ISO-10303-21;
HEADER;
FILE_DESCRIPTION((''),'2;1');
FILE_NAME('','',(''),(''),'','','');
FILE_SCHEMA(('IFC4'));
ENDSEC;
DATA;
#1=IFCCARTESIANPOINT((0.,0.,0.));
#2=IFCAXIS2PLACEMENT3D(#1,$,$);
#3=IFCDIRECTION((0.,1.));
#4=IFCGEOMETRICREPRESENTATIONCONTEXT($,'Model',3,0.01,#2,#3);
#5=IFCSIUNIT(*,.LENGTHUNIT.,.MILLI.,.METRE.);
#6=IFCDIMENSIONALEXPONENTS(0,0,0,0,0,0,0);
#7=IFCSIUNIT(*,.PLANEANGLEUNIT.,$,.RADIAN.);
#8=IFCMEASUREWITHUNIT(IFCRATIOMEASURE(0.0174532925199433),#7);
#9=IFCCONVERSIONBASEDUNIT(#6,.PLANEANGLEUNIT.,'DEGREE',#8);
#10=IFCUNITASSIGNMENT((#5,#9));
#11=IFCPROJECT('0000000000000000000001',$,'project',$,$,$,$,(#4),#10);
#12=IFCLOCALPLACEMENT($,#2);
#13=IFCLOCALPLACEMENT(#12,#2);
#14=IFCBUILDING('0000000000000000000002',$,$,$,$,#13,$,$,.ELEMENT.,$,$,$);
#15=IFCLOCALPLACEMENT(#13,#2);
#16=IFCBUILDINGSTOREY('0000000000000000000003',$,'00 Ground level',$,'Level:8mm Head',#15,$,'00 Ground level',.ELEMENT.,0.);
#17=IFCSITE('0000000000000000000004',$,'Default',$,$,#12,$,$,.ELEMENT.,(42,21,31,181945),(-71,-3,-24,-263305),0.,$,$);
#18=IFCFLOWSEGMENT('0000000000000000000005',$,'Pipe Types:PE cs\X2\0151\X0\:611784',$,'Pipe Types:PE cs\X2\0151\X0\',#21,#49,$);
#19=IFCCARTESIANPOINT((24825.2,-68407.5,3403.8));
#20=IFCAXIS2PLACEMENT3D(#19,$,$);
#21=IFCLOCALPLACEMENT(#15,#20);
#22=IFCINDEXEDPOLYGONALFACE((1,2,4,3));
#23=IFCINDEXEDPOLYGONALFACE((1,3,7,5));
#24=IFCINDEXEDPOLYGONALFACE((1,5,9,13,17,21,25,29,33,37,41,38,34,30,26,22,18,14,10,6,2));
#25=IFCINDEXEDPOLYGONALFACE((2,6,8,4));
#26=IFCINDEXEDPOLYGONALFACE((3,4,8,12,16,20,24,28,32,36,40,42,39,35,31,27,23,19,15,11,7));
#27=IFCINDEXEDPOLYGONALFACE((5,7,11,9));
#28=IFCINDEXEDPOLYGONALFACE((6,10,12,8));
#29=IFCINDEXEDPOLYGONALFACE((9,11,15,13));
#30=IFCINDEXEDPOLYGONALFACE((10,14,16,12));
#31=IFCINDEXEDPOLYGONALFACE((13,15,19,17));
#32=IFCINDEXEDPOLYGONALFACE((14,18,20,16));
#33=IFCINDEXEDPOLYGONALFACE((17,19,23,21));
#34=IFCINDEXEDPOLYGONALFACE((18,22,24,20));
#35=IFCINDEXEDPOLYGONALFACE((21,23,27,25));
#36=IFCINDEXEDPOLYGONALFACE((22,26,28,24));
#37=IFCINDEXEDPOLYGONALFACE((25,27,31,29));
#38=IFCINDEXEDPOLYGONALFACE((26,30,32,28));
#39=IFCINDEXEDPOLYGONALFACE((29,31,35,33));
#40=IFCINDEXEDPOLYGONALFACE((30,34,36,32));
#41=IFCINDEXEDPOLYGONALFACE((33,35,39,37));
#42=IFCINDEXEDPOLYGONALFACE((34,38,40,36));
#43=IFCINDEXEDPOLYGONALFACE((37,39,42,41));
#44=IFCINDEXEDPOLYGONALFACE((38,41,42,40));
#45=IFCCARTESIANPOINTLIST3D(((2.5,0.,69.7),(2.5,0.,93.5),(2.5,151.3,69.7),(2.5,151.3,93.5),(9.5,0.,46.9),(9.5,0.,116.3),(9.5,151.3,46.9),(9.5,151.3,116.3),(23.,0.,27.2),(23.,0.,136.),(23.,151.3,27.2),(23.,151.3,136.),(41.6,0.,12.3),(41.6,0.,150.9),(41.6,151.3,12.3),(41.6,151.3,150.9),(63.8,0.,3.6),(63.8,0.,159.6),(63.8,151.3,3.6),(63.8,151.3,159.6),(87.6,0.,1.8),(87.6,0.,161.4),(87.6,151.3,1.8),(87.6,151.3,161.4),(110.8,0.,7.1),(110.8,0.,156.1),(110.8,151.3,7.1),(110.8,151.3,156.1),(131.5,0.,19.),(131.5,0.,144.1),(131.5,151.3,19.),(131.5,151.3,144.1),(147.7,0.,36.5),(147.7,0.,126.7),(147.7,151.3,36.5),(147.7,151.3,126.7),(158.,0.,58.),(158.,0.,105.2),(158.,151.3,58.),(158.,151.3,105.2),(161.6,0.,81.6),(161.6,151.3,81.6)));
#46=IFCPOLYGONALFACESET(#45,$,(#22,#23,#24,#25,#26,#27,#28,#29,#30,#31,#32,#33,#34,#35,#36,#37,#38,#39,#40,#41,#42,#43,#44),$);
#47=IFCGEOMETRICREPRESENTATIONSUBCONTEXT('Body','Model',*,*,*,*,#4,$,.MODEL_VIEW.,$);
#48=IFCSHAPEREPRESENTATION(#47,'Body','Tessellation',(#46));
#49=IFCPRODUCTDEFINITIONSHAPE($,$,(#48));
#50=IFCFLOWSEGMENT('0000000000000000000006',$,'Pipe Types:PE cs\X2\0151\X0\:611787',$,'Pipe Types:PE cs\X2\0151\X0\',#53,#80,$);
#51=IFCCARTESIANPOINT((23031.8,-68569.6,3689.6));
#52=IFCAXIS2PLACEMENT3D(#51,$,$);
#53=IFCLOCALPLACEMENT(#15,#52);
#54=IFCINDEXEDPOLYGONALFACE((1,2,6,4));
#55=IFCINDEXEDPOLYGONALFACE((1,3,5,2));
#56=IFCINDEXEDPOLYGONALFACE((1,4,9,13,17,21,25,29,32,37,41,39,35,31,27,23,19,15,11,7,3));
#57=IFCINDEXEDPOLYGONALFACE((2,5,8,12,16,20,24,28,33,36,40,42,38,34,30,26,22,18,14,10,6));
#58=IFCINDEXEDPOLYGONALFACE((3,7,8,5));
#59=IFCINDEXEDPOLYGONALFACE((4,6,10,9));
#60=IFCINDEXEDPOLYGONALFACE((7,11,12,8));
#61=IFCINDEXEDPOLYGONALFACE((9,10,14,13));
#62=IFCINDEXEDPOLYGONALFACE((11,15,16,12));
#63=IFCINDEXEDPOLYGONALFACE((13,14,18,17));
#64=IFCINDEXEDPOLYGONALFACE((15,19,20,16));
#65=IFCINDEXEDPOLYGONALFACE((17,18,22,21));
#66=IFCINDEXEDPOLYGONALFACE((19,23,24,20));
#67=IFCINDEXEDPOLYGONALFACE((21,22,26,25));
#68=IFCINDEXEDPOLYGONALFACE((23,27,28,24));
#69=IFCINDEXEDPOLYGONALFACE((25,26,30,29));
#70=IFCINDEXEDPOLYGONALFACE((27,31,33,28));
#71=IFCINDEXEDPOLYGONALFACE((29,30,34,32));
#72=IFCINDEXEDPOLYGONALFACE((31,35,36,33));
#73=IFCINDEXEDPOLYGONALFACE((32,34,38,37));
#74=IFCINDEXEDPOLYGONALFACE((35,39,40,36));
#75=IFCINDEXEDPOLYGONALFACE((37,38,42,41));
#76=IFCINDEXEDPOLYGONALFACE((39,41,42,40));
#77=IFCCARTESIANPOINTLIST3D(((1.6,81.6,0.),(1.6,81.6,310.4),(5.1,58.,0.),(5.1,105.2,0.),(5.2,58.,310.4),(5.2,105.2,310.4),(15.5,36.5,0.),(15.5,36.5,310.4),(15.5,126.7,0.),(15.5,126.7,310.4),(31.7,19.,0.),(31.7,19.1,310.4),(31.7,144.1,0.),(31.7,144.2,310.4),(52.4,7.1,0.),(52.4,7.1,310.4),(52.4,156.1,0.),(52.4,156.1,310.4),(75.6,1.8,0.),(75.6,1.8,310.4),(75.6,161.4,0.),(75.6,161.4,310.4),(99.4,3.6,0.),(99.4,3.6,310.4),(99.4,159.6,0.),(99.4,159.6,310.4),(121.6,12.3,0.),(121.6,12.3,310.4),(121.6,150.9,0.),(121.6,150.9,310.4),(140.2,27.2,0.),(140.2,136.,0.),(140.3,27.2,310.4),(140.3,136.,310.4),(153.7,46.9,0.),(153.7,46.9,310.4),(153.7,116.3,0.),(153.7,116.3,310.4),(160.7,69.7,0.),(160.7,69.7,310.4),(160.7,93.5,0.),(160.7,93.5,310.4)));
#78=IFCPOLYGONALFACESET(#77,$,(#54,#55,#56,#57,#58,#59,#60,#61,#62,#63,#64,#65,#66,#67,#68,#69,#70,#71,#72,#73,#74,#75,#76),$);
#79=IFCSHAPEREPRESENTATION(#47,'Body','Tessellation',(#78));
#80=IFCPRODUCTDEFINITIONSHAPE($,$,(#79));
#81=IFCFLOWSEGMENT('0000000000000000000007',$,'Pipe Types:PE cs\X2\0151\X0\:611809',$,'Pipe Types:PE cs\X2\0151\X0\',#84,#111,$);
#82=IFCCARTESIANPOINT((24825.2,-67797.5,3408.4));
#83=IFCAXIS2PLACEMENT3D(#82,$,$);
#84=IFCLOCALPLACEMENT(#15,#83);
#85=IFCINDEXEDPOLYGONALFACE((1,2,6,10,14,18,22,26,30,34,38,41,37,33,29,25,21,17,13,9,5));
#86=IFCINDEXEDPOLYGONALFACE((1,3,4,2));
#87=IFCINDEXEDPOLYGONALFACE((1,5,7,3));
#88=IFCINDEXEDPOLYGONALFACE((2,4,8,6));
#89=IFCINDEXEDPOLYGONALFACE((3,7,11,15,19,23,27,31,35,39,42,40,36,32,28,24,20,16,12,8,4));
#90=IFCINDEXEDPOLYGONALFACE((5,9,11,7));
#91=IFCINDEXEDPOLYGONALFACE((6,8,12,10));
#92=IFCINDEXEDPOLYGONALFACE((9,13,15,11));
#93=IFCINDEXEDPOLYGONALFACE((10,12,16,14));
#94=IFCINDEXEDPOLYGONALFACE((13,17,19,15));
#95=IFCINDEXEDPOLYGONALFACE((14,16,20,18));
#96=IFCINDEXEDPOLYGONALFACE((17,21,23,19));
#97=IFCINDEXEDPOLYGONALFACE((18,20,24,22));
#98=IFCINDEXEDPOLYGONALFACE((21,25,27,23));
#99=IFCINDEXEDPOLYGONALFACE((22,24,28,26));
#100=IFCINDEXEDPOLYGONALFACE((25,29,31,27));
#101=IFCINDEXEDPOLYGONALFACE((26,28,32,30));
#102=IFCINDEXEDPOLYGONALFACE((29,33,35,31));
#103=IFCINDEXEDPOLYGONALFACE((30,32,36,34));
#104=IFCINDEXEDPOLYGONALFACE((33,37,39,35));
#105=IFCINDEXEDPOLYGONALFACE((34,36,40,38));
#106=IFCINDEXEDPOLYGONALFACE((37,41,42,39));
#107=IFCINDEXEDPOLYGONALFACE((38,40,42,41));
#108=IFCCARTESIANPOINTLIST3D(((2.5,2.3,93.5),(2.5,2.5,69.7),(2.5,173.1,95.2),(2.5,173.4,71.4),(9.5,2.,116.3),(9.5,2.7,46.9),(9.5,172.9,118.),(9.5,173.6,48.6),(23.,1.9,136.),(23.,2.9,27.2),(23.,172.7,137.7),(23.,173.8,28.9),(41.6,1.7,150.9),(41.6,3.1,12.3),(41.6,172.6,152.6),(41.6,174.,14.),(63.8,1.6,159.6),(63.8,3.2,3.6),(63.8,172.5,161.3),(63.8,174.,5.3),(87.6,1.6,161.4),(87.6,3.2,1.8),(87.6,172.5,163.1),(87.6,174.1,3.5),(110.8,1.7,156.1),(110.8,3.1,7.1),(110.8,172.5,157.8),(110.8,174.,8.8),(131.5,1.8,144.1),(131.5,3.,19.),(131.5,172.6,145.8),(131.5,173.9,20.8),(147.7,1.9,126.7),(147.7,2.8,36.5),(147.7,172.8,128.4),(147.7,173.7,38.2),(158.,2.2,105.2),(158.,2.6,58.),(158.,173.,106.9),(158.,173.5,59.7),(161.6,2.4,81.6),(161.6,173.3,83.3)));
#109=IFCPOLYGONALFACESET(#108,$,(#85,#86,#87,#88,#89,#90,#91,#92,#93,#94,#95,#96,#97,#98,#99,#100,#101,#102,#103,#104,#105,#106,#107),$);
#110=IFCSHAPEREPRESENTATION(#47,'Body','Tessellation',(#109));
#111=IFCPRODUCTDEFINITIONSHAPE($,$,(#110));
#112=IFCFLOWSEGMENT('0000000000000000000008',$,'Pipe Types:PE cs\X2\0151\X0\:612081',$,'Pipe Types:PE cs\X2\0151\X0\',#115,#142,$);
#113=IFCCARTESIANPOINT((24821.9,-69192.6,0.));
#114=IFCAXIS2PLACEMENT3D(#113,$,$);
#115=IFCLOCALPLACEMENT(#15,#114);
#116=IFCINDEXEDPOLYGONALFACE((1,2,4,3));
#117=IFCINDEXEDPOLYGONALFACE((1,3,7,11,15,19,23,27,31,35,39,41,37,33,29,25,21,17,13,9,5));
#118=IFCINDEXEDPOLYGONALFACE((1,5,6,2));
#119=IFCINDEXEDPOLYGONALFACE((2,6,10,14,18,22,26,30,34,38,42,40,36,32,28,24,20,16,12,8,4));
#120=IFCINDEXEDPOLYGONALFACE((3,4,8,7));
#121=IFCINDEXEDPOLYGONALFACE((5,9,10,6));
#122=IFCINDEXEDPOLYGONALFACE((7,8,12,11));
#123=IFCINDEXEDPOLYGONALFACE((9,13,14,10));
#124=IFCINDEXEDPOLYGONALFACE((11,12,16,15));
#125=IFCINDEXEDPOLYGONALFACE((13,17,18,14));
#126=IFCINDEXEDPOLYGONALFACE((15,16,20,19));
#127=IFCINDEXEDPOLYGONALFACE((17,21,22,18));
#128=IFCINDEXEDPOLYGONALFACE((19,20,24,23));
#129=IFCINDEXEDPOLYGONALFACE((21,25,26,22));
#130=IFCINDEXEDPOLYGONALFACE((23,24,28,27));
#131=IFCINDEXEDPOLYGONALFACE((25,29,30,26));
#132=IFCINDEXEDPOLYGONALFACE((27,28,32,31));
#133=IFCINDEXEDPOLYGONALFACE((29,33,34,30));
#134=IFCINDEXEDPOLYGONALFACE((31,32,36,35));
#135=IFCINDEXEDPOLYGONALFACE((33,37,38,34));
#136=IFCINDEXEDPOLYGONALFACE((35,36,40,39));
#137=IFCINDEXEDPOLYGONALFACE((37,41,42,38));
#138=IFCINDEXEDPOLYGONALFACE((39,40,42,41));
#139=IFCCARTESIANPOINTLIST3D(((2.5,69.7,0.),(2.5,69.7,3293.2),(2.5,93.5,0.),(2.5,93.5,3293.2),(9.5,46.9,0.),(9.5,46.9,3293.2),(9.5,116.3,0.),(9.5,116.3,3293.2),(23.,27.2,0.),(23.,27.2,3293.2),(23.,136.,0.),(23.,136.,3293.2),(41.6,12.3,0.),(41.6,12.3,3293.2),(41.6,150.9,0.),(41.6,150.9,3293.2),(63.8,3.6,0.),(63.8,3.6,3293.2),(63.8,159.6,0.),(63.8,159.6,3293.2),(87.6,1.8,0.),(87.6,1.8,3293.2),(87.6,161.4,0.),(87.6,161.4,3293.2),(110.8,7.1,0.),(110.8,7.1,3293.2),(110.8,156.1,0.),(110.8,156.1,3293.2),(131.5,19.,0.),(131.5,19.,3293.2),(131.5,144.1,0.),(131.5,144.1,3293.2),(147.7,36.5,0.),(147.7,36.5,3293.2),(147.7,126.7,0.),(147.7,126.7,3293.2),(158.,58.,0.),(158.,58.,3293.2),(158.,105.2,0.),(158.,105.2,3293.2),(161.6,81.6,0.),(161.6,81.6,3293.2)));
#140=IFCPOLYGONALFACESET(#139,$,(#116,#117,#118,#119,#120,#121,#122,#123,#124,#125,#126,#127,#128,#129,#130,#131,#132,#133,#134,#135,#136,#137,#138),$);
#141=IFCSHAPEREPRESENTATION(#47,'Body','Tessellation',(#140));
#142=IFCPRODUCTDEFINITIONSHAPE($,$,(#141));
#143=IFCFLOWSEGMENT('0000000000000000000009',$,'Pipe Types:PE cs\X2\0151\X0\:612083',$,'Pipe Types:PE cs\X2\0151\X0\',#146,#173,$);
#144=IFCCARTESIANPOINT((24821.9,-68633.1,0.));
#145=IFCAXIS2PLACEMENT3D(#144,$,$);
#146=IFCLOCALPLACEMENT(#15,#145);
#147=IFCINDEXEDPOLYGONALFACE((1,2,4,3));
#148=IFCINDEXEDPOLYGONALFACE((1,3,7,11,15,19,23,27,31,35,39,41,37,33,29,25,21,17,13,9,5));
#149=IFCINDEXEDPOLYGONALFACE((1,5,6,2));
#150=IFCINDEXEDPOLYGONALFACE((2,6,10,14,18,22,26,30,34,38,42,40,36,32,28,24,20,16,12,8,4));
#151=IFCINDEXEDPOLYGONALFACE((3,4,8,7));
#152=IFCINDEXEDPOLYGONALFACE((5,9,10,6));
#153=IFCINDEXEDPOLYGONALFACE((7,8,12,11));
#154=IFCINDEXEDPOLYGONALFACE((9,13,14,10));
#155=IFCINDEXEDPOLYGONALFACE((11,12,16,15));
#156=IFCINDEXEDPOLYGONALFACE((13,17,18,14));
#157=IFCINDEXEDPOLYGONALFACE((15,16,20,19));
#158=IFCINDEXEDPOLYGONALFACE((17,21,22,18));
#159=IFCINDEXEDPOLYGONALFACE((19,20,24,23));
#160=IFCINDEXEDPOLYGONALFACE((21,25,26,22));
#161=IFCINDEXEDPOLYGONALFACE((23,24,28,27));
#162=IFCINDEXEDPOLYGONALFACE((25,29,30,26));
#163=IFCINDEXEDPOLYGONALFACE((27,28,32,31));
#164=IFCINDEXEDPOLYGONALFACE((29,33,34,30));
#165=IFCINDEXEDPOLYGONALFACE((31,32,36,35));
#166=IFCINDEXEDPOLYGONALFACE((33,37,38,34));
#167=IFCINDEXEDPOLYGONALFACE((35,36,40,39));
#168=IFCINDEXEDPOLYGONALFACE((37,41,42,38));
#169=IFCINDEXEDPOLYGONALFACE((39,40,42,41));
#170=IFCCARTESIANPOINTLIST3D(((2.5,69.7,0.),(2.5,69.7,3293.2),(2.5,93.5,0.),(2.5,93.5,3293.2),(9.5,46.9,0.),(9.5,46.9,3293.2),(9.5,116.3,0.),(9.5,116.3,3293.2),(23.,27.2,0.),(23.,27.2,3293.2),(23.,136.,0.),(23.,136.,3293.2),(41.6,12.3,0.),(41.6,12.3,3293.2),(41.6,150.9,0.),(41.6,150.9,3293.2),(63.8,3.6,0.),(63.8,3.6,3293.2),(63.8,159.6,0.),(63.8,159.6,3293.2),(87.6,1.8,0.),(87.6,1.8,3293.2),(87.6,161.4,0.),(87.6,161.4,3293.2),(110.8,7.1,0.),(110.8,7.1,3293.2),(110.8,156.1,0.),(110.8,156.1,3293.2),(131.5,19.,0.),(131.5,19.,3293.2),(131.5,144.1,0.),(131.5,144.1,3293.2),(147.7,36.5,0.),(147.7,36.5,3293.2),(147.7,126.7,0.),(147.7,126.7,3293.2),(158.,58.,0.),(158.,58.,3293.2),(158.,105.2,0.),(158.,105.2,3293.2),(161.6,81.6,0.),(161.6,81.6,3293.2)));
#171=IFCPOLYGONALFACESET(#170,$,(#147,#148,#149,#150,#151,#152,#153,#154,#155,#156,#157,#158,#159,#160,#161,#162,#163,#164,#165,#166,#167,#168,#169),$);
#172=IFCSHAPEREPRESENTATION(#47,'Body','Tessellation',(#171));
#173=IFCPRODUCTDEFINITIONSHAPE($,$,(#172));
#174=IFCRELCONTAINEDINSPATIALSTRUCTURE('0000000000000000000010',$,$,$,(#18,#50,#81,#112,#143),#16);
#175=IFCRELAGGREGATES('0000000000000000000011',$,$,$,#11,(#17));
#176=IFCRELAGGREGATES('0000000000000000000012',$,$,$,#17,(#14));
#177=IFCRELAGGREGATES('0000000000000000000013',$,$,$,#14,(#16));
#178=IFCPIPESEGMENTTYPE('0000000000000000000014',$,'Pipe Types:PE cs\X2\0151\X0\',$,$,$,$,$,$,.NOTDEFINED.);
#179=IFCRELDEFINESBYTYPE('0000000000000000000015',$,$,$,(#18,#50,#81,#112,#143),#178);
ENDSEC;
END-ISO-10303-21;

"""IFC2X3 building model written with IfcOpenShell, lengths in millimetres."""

from ifc_helpers import new_model, entity, si_unit, converted_unit, direction, frame, frame_2d, origin, origin_2d_with_axis, place, context, subcontext, project, spatial, circle, extrude, type_object, element, save


model = new_model("IFC2X3")

# Units and contexts
model_context = context("Model", 3, precision=0.01, world=origin(), true_north=direction((0.0, 1.0)))
body_context = subcontext(model_context, "Body", "Model", "MODEL_VIEW")
ifc_project = project(units=[si_unit("LENGTHUNIT", "METRE", prefix="MILLI"), converted_unit("PLANEANGLEUNIT", "DEGREE", entity("IfcRatioMeasure", 0.0174532925199433), si_unit("PLANEANGLEUNIT", "RADIAN"), dimensions=[0, 0, 0, 0, 0, 0, 0])], contexts=[model_context])

# Site, building, storey
site_placement = place(None, origin())
site = spatial("IfcSite", under=ifc_project, at=site_placement, Name="Default", CompositionType="ELEMENT", RefLatitude=(42, 21, 31, 181945), RefLongitude=(-71, -3, -24, -263305), RefElevation=0.0)
building_placement = place(site_placement, origin())
building = spatial("IfcBuilding", under=site, at=building_placement, CompositionType="ELEMENT")
storey_placement = place(building_placement, origin())
storey = spatial("IfcBuildingStorey", under=building, at=storey_placement, Name="00 Ground level", ObjectType="Level:8mm Head", LongName="00 Ground level", CompositionType="ELEMENT", Elevation=0.0)

# Flow segments
pipe_segment_type = type_object("IfcPipeSegmentType", Name="Pipe Types:PE cső", PredefinedType="NOTDEFINED")
flow_segment_1_placement = place(storey_placement, frame((24825.2, -68407.5, 3403.8)))
element("IfcFlowSegment", 1, at=flow_segment_1_placement, inside=storey, type_object=pipe_segment_type, Name="Pipe Types:PE cső:611784", ObjectType="Pipe Types:PE cső", context=body_context, shape_type="SweptSolid", body=[
    extrude(circle(Radius=80.0, at=origin_2d_with_axis()), frame((81.6, 0.0, 81.6), z_axis=(0.0, 1.0, 0.0), x_axis=(1.0, 0.0, 0.0)), (0.0, 0.0, 1.0), 151.3),
])
flow_segment_2_placement = place(storey_placement, frame((23031.8, -68569.6, 3689.6)))
element("IfcFlowSegment", 2, at=flow_segment_2_placement, inside=storey, type_object=pipe_segment_type, Name="Pipe Types:PE cső:611787", ObjectType="Pipe Types:PE cső", context=body_context, shape_type="SweptSolid", body=[
    extrude(circle(Radius=80.0, at=frame_2d((0.0, 0.0), x_axis=(1.0, 0.0))), frame((81.6, 81.6, 0.0), z_axis=(0.000084, 0.000051, 1.0), x_axis=(-1.0, 0.0, 0.000084)), (0.0, 0.0, 1.0), 310.4),
])
flow_segment_3_placement = place(storey_placement, frame((24825.2, -67797.5, 3408.4)))
element("IfcFlowSegment", 3, at=flow_segment_3_placement, inside=storey, type_object=pipe_segment_type, Name="Pipe Types:PE cső:611809", ObjectType="Pipe Types:PE cső", context=body_context, shape_type="SweptSolid", body=[
    extrude(circle(Radius=80.0, at=origin_2d_with_axis()), frame((81.6, 2.4, 81.6), z_axis=(0.0, 0.99995, 0.01), x_axis=(1.0, 0.0, 0.0)), (0.0, 0.0, 1.0), 170.9),
])
for number, where, name in (
    (4, (24821.9, -69192.6, 0.0), "Pipe Types:PE cső:612081"),
    (5, (24821.9, -68633.1, 0.0), "Pipe Types:PE cső:612083"),
):
    element("IfcFlowSegment", number, at=place(storey_placement, frame(where)), inside=storey, type_object=pipe_segment_type, Name=name, ObjectType="Pipe Types:PE cső", context=body_context, shape_type="SweptSolid", body=[
        extrude(circle(Radius=80.0, at=frame_2d((0.0, 0.0), x_axis=(1.0, 0.0))), frame((81.6, 81.6, 0.0)), (0.0, 0.0, 1.0), 3293.2),
    ])

save(model, "model.ifc")
